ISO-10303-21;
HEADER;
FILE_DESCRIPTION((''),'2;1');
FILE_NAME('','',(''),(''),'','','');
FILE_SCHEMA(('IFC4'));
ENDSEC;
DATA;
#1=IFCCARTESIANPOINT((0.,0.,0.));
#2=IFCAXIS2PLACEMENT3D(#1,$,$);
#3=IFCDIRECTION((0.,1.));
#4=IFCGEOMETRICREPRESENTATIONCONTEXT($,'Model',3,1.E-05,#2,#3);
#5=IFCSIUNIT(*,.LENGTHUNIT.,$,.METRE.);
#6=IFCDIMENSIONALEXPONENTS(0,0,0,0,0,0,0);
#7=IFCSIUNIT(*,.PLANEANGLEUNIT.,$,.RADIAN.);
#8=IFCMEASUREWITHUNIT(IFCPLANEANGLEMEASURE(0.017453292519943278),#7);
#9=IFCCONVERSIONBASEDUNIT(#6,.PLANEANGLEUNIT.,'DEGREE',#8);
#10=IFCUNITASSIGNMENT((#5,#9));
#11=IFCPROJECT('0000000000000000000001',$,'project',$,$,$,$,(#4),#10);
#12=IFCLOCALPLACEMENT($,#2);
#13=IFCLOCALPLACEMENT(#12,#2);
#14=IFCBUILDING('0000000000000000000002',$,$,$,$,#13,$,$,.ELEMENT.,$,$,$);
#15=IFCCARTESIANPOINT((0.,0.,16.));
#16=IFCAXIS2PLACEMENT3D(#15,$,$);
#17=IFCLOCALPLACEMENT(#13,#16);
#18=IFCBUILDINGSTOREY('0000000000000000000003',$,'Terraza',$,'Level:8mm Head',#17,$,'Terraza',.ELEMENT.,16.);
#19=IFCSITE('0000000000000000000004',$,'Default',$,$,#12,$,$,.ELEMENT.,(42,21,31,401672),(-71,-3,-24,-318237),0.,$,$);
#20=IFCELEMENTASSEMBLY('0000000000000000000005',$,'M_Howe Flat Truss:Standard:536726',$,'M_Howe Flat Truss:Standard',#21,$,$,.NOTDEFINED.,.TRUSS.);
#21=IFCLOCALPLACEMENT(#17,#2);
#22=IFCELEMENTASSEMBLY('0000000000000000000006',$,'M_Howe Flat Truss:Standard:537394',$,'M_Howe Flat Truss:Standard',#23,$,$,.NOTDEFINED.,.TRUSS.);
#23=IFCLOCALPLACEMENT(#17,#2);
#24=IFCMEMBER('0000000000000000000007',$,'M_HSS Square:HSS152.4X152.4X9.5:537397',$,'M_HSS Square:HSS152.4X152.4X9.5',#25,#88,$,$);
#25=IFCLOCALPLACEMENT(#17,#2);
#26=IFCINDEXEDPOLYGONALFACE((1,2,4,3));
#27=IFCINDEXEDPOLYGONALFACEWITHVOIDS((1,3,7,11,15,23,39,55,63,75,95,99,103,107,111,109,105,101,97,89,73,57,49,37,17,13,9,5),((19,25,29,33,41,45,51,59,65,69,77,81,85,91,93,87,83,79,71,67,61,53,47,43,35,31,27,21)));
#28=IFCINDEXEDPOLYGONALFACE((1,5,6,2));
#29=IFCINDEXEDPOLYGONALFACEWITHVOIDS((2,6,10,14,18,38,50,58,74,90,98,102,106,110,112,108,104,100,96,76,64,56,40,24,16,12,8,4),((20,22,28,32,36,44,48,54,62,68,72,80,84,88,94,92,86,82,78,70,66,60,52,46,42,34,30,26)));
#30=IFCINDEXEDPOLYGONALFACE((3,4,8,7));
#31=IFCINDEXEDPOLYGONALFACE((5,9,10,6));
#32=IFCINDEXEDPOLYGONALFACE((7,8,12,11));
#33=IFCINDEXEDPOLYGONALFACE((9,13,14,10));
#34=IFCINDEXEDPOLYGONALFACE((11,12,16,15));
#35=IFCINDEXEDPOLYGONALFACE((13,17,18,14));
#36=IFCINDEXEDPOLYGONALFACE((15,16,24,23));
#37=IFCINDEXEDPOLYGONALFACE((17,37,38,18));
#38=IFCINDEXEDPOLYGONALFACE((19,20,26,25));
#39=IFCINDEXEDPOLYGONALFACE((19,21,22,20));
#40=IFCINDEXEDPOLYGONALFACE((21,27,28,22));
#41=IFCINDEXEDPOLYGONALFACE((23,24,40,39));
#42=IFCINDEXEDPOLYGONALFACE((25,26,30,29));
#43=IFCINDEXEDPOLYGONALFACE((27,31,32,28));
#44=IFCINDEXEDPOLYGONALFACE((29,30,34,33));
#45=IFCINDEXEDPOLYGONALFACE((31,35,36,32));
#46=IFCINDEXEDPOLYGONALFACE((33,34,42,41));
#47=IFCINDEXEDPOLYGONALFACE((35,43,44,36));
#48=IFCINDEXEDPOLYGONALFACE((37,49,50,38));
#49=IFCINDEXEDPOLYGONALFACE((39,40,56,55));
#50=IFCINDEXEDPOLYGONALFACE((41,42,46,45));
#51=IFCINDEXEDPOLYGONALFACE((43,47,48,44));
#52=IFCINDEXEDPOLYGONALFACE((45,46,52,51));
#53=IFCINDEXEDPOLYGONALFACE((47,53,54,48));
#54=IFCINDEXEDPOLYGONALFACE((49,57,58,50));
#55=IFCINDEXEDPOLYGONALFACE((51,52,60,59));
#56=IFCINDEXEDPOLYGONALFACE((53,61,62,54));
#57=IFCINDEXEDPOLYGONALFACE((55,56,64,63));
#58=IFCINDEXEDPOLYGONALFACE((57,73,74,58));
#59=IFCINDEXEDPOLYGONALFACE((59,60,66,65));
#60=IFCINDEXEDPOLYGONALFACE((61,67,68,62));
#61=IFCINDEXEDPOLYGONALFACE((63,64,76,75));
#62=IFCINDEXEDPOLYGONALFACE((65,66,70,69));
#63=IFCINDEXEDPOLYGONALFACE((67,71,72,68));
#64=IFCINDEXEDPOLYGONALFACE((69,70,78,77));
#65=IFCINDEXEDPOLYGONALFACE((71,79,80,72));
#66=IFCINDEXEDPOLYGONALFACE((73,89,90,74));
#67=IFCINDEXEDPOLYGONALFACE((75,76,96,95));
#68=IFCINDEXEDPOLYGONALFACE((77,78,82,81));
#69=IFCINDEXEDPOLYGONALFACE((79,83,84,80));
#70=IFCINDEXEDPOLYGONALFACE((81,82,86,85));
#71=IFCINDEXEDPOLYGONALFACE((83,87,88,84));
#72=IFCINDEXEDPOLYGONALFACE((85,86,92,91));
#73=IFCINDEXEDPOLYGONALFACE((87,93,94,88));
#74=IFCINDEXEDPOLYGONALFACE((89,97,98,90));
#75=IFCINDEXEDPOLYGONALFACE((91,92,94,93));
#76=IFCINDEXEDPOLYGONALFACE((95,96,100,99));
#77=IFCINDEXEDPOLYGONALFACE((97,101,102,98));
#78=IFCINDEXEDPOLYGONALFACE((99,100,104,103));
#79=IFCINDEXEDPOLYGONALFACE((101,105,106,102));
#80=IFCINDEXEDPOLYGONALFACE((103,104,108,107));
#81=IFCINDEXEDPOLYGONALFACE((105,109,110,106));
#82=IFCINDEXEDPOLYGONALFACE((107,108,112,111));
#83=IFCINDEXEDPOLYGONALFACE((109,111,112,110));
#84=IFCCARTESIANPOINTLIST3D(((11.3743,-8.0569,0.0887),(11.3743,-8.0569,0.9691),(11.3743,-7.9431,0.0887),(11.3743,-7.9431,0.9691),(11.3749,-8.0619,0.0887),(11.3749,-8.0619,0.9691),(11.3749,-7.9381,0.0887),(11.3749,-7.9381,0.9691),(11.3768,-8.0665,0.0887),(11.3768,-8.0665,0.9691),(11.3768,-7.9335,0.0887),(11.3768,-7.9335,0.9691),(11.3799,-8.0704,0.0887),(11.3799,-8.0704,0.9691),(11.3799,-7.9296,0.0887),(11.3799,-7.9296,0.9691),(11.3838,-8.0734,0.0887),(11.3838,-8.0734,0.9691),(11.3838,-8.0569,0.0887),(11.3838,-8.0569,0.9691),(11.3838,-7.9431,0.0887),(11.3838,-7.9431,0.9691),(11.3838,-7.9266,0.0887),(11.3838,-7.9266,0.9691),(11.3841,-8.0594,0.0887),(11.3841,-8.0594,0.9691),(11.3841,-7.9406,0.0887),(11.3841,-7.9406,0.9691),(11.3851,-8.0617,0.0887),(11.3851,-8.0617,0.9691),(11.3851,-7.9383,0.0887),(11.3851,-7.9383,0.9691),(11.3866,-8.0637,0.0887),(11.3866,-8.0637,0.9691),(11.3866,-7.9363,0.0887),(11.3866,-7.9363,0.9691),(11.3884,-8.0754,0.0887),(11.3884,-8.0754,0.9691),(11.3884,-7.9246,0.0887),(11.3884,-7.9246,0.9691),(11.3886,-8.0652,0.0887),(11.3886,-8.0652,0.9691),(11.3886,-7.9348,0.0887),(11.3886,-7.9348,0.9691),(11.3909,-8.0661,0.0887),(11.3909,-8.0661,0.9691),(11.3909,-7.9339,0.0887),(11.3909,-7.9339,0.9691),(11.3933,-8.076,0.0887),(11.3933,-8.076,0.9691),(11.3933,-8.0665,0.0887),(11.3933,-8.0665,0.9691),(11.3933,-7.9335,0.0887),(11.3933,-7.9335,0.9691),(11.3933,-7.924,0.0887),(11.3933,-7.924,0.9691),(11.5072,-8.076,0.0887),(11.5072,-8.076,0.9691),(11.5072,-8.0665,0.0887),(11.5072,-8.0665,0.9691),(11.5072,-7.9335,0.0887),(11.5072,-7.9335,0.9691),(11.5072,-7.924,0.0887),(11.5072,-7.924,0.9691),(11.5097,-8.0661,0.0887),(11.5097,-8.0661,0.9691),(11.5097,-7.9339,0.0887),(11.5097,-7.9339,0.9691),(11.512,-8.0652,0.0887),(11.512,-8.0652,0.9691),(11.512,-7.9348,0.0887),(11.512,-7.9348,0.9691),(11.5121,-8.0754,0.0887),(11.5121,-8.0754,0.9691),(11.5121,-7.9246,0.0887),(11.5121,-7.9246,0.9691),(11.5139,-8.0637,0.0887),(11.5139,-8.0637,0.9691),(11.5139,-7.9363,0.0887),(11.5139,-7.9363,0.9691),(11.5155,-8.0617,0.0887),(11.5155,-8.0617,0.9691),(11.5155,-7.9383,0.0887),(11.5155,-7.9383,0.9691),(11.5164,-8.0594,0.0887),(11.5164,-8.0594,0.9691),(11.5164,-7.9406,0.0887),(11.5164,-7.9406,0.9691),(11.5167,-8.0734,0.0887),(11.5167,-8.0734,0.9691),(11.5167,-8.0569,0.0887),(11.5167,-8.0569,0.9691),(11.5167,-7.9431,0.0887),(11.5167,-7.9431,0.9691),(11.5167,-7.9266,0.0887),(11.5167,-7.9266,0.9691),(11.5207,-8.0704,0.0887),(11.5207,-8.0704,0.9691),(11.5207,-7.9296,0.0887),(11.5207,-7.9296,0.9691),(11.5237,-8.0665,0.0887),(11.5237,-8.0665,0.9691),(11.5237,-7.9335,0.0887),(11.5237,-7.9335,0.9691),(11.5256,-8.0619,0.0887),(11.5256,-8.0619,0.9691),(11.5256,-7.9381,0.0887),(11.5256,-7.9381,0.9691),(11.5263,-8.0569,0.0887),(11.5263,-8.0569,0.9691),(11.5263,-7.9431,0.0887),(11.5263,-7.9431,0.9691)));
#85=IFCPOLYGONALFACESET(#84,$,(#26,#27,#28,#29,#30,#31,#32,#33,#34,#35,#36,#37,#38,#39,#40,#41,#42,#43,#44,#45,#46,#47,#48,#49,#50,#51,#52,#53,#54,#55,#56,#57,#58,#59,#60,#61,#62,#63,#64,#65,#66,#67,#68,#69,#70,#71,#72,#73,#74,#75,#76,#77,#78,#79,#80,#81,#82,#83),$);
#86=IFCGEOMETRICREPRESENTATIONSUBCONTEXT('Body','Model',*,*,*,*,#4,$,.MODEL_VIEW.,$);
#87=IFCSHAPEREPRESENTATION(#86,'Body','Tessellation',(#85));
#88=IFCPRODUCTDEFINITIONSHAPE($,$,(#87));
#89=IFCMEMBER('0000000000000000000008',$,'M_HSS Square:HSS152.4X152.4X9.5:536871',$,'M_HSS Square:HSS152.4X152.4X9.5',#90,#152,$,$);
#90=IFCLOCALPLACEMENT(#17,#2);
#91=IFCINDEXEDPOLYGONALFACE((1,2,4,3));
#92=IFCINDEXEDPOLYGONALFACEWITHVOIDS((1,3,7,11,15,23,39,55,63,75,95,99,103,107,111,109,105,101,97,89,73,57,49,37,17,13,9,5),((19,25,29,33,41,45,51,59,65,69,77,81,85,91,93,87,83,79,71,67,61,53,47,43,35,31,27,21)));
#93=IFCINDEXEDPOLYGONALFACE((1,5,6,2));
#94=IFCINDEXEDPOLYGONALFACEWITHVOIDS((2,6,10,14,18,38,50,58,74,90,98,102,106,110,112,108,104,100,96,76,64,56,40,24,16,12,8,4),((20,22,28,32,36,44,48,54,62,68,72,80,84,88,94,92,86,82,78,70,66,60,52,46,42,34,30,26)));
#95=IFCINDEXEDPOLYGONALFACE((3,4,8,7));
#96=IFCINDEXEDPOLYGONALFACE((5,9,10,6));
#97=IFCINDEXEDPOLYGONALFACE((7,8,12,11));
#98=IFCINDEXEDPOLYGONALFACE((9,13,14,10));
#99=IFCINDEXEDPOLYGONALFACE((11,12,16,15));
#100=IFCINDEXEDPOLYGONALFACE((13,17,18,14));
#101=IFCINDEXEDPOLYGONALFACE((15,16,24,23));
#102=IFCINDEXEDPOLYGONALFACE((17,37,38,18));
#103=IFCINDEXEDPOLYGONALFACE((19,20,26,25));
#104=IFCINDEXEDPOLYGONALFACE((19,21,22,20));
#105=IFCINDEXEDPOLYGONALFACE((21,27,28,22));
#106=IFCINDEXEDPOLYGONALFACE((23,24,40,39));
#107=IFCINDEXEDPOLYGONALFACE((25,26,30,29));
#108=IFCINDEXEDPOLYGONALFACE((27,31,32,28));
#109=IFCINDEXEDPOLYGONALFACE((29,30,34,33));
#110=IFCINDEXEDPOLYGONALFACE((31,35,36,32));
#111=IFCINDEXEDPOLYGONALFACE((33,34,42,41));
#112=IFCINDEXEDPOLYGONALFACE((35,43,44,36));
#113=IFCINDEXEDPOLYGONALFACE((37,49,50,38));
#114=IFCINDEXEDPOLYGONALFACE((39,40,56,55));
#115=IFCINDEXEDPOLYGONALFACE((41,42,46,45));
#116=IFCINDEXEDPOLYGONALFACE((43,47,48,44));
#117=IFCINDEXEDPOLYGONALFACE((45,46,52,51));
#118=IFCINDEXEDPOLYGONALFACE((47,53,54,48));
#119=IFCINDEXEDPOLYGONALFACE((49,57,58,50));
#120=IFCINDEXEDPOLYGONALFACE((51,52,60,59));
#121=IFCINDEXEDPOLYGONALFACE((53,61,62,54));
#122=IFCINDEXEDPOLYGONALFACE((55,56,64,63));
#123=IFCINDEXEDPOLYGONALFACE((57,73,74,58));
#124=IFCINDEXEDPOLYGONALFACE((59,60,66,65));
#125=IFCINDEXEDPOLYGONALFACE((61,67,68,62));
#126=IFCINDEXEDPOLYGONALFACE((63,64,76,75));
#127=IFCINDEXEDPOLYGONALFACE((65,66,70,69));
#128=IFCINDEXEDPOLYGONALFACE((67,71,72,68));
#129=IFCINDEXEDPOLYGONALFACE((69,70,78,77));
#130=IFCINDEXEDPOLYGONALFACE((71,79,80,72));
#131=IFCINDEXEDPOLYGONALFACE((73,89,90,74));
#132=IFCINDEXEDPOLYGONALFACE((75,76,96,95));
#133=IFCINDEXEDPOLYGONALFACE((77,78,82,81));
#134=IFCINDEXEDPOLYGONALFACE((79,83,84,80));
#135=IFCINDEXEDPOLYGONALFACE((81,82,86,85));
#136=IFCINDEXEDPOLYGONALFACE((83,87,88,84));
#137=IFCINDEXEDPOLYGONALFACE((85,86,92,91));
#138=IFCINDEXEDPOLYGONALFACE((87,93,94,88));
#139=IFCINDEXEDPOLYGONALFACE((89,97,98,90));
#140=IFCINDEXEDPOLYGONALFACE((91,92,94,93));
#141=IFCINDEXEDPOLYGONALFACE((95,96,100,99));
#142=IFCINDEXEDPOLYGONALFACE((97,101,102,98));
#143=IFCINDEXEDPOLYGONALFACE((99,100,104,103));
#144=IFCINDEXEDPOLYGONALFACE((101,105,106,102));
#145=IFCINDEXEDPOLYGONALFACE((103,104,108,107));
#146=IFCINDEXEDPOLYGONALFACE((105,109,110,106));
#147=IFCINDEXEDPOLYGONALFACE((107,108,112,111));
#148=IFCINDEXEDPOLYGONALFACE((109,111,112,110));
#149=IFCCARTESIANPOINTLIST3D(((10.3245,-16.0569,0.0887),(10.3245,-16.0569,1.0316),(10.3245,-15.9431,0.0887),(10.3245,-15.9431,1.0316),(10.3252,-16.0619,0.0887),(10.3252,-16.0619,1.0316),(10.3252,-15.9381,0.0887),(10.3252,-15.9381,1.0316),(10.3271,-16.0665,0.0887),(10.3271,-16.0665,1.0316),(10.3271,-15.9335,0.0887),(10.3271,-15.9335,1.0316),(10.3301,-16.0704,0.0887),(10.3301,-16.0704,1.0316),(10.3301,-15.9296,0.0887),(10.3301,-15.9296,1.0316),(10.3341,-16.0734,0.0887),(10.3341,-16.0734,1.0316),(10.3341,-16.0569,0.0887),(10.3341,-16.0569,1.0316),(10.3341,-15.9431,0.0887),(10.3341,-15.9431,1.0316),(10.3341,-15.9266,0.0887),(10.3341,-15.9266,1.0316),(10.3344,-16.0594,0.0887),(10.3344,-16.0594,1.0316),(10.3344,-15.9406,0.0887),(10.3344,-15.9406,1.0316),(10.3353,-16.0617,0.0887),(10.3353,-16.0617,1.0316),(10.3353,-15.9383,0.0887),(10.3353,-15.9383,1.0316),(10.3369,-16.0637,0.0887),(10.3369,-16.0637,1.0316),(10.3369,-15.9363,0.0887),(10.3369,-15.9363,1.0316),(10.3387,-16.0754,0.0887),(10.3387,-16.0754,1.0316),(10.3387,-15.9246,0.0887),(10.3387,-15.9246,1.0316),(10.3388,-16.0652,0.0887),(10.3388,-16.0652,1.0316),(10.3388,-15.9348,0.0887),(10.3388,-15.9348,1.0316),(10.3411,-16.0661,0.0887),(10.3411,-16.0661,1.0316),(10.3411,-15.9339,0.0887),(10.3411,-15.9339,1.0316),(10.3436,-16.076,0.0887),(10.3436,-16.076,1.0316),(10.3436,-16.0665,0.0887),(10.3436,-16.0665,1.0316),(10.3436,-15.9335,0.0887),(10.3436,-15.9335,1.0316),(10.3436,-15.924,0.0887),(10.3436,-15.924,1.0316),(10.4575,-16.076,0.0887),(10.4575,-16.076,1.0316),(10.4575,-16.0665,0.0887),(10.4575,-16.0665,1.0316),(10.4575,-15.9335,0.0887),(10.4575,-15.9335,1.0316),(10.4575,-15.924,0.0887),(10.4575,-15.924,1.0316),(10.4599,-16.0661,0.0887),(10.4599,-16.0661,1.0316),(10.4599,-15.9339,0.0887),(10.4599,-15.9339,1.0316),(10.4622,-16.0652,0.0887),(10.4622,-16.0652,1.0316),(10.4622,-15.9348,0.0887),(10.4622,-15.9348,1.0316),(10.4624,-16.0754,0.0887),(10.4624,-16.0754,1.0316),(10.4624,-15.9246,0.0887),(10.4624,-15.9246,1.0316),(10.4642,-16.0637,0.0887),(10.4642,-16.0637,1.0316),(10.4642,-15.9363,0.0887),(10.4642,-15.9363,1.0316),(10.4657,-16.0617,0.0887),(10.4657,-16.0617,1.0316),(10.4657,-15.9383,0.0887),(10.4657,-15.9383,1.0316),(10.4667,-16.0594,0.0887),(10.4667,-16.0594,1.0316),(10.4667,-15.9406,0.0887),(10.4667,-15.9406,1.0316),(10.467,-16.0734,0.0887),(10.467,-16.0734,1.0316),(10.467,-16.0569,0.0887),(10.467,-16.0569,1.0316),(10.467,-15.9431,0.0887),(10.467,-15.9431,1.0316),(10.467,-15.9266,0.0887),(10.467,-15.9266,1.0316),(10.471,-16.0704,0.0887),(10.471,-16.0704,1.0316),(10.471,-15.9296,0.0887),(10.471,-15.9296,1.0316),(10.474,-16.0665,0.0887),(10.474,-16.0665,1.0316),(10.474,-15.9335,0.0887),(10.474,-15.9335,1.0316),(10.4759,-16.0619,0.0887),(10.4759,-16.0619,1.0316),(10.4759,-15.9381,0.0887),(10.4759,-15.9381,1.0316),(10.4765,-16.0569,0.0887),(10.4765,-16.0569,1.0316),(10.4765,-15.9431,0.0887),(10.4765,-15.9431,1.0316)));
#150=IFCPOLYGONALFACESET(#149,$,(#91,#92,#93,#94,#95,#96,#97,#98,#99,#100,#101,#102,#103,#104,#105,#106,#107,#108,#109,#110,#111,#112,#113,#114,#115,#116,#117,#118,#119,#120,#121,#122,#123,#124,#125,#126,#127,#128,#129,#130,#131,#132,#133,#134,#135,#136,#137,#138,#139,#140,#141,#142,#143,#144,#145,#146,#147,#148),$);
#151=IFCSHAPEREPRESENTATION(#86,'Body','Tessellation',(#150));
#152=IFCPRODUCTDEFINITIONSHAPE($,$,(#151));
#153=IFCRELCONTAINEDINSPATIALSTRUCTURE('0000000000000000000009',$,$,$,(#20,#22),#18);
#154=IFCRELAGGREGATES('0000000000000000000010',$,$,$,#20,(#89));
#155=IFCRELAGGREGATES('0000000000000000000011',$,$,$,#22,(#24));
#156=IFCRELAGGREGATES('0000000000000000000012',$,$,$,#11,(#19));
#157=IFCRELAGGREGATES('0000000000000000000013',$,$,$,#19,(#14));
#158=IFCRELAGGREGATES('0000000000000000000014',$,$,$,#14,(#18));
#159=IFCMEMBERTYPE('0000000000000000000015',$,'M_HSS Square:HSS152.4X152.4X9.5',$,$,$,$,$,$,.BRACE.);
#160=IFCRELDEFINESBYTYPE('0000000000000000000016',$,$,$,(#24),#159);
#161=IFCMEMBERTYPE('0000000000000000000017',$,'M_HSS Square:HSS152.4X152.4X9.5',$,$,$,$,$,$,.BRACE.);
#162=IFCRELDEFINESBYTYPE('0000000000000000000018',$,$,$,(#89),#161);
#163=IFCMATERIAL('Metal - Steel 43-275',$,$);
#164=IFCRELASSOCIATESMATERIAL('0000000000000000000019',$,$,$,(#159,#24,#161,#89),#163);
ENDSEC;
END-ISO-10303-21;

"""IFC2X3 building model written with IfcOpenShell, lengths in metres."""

from ifc_helpers import new_model, entity, si_unit, converted_unit, direction, frame, frame_2d, origin, place, context, subcontext, project, spatial, polyline, circle_curve, parameter, trimmed, segment, composite_curve, outline, extrude, source, transform, mapped, material, type_object, type_shapes, element, aggregate, save


model = new_model("IFC2X3")

# Units and contexts
model_context = context("Model", 3, precision=1e-05, world=origin(), true_north=direction((0.0, 1.0)))
body_context = subcontext(model_context, "Body", "Model", "MODEL_VIEW")
ifc_project = project(units=[si_unit("LENGTHUNIT", "METRE"), converted_unit("PLANEANGLEUNIT", "DEGREE", entity("IfcPlaneAngleMeasure", 0.017453292519943278), si_unit("PLANEANGLEUNIT", "RADIAN"), dimensions=[0, 0, 0, 0, 0, 0, 0])], contexts=[model_context])

# Site, building, storey
site_placement = place(None, origin())
site = spatial("IfcSite", under=ifc_project, at=site_placement, Name="Default", CompositionType="ELEMENT", RefLatitude=(42, 21, 31, 401672), RefLongitude=(-71, -3, -24, -318237), RefElevation=0.0)
building_placement = place(site_placement, origin())
building = spatial("IfcBuilding", under=site, at=building_placement, CompositionType="ELEMENT")
storey_placement = place(building_placement, frame((0.0, 0.0, 16.0)))
storey = spatial("IfcBuildingStorey", under=building, at=storey_placement, Name="Terraza", ObjectType="Level:8mm Head", LongName="Terraza", CompositionType="ELEMENT", Elevation=16.0)

# Element assemblies, member
assembly_1_placement = place(storey_placement, origin())
assembly_1 = element("IfcElementAssembly", 1, at=assembly_1_placement, inside=storey, Name="M_Howe Flat Truss:Standard:536726", ObjectType="M_Howe Flat Truss:Standard", AssemblyPlace="NOTDEFINED", PredefinedType="TRUSS")
ifc_material = material(Name="Metal - Steel 43-275")
member_type_1 = type_object("IfcMemberType", Name="M_HSS Square:HSS152.4X152.4X9.5", PredefinedType="BRACE", material=ifc_material)
shared_shape_1 = source(origin(), body_context, "Body", "SweptSolid", [
    extrude(outline(composite_curve([segment(polyline([(-0.0569, -0.076), (0.0569, -0.076)]), True, "CONTINUOUS"), segment(trimmed(circle_curve(frame_2d((0.0569, -0.0569), x_axis=(0.0, 1.0)), 0.0191), [parameter(180.0)], [parameter(270.0)], True, "PARAMETER"), True, "CONTINUOUS"), segment(polyline([(0.076, -0.0569), (0.076, 0.0569)]), True, "CONTINUOUS"), segment(trimmed(circle_curve(frame_2d((0.0569, 0.0569), x_axis=(0.0, 1.0)), 0.0191), [parameter(270.0)], [parameter(0.0)], True, "PARAMETER"), True, "CONTINUOUS"), segment(polyline([(0.0569, 0.076), (-0.0569, 0.076)]), True, "CONTINUOUS"), segment(trimmed(circle_curve(frame_2d((-0.0569, 0.0569), x_axis=(0.0, 1.0)), 0.0191), [parameter(0.0)], [parameter(90.0)], True, "PARAMETER"), True, "CONTINUOUS"), segment(polyline([(-0.076, 0.0569), (-0.076, -0.0569)]), True, "CONTINUOUS"), segment(trimmed(circle_curve(frame_2d((-0.0569, -0.0569), x_axis=(0.0, 1.0)), 0.0191), [parameter(90.0)], [parameter(180.0)], True, "PARAMETER"), True, "CONTINUOUS")], self_intersect=False), holes=[composite_curve([segment(trimmed(circle_curve(frame_2d((-0.0569, 0.0569), x_axis=(0.0, 1.0)), 0.0095), [parameter(360.0)], [parameter(90.0)], True, "PARAMETER"), False, "CONTINUOUS"), segment(polyline([(-0.0569, 0.0665), (0.0569, 0.0665)]), True, "CONTINUOUS"), segment(trimmed(circle_curve(frame_2d((0.0569, 0.0569), x_axis=(0.0, 1.0)), 0.0095), [parameter(270.0)], [parameter(360.0)], True, "PARAMETER"), False, "CONTINUOUS"), segment(polyline([(0.0665, 0.0569), (0.0665, -0.0569)]), True, "CONTINUOUS"), segment(trimmed(circle_curve(frame_2d((0.0569, -0.0569), x_axis=(0.0, 1.0)), 0.0095), [parameter(180.0)], [parameter(270.0)], True, "PARAMETER"), False, "CONTINUOUS"), segment(polyline([(0.0569, -0.0665), (-0.0569, -0.0665)]), True, "CONTINUOUS"), segment(trimmed(circle_curve(frame_2d((-0.0569, -0.0569), x_axis=(0.0, 1.0)), 0.0095), [parameter(90.0)], [parameter(180.0)], True, "PARAMETER"), False, "CONTINUOUS"), segment(polyline([(-0.0665, -0.0569), (-0.0665, 0.0569)]), True, "CONTINUOUS")], self_intersect=False)]), frame((-0.4426, 0.0, 0.0), z_axis=(1.0, 0.0, 0.0), x_axis=(0.0, 0.0, -1.0)), (0.0, 0.0, 1.0), 0.8804),
])
type_shapes(member_type_1, [shared_shape_1])
assembly_2_placement = place(storey_placement, origin())
assembly_2 = element("IfcElementAssembly", 2, at=assembly_2_placement, inside=storey, Name="M_Howe Flat Truss:Standard:537394", ObjectType="M_Howe Flat Truss:Standard", AssemblyPlace="NOTDEFINED", PredefinedType="TRUSS")
member_1_placement = place(assembly_2_placement, frame((11.4503, -8.0, 0.5312), z_axis=(1.0, 0.0, 0.0), x_axis=(0.0, 0.0, 1.0)))
member_1 = element("IfcMember", 3, at=member_1_placement, type_object=member_type_1, material=ifc_material, Name="M_HSS Square:HSS152.4X152.4X9.5:537397", ObjectType="M_HSS Square:HSS152.4X152.4X9.5", context=body_context, shape_type="MappedRepresentation", body=[
    mapped(shared_shape_1, transform((0.0, 0.0, 0.0), scale=1.0)),
])

# Member
member_type_2 = type_object("IfcMemberType", Name="M_HSS Square:HSS152.4X152.4X9.5", PredefinedType="BRACE", material=ifc_material)
shared_shape_2 = source(origin(), body_context, "Body", "SweptSolid", [
    extrude(outline(composite_curve([segment(polyline([(-0.0569, -0.076), (0.0569, -0.076)]), True, "CONTINUOUS"), segment(trimmed(circle_curve(frame_2d((0.0569, -0.0569), x_axis=(0.0, 1.0)), 0.0191), [parameter(180.0)], [parameter(270.0)], True, "PARAMETER"), True, "CONTINUOUS"), segment(polyline([(0.076, -0.0569), (0.076, 0.0569)]), True, "CONTINUOUS"), segment(trimmed(circle_curve(frame_2d((0.0569, 0.0569), x_axis=(0.0, 1.0)), 0.0191), [parameter(270.0)], [parameter(0.0)], True, "PARAMETER"), True, "CONTINUOUS"), segment(polyline([(0.0569, 0.076), (-0.0569, 0.076)]), True, "CONTINUOUS"), segment(trimmed(circle_curve(frame_2d((-0.0569, 0.0569), x_axis=(0.0, 1.0)), 0.0191), [parameter(0.0)], [parameter(90.0)], True, "PARAMETER"), True, "CONTINUOUS"), segment(polyline([(-0.076, 0.0569), (-0.076, -0.0569)]), True, "CONTINUOUS"), segment(trimmed(circle_curve(frame_2d((-0.0569, -0.0569), x_axis=(0.0, 1.0)), 0.0191), [parameter(90.0)], [parameter(180.0)], True, "PARAMETER"), True, "CONTINUOUS")], self_intersect=False), holes=[composite_curve([segment(trimmed(circle_curve(frame_2d((-0.0569, 0.0569), x_axis=(0.0, 1.0)), 0.0095), [parameter(360.0)], [parameter(90.0)], True, "PARAMETER"), False, "CONTINUOUS"), segment(polyline([(-0.0569, 0.0665), (0.0569, 0.0665)]), True, "CONTINUOUS"), segment(trimmed(circle_curve(frame_2d((0.0569, 0.0569), x_axis=(0.0, 1.0)), 0.0095), [parameter(270.0)], [parameter(360.0)], True, "PARAMETER"), False, "CONTINUOUS"), segment(polyline([(0.0665, 0.0569), (0.0665, -0.0569)]), True, "CONTINUOUS"), segment(trimmed(circle_curve(frame_2d((0.0569, -0.0569), x_axis=(0.0, 1.0)), 0.0095), [parameter(180.0)], [parameter(270.0)], True, "PARAMETER"), False, "CONTINUOUS"), segment(polyline([(0.0569, -0.0665), (-0.0569, -0.0665)]), True, "CONTINUOUS"), segment(trimmed(circle_curve(frame_2d((-0.0569, -0.0569), x_axis=(0.0, 1.0)), 0.0095), [parameter(90.0)], [parameter(180.0)], True, "PARAMETER"), False, "CONTINUOUS"), segment(polyline([(-0.0665, -0.0569), (-0.0665, 0.0569)]), True, "CONTINUOUS")], self_intersect=False)]), frame((-0.4738, 0.0, 0.0), z_axis=(1.0, 0.0, 0.0), x_axis=(0.0, 0.0, -1.0)), (0.0, 0.0, 1.0), 0.9429),
])
type_shapes(member_type_2, [shared_shape_2])
member_2_placement = place(assembly_1_placement, frame((10.4005, -16.0, 0.5625), z_axis=(1.0, 0.0, 0.0), x_axis=(0.0, 0.0, 1.0)))
member_2 = element("IfcMember", 4, at=member_2_placement, type_object=member_type_2, material=ifc_material, Name="M_HSS Square:HSS152.4X152.4X9.5:536871", ObjectType="M_HSS Square:HSS152.4X152.4X9.5", context=body_context, shape_type="MappedRepresentation", body=[
    mapped(shared_shape_2, transform((0.0, 0.0, 0.0), scale=1.0)),
])

aggregate(assembly_1, [member_2])
aggregate(assembly_2, [member_1])

save(model, "model.ifc")
